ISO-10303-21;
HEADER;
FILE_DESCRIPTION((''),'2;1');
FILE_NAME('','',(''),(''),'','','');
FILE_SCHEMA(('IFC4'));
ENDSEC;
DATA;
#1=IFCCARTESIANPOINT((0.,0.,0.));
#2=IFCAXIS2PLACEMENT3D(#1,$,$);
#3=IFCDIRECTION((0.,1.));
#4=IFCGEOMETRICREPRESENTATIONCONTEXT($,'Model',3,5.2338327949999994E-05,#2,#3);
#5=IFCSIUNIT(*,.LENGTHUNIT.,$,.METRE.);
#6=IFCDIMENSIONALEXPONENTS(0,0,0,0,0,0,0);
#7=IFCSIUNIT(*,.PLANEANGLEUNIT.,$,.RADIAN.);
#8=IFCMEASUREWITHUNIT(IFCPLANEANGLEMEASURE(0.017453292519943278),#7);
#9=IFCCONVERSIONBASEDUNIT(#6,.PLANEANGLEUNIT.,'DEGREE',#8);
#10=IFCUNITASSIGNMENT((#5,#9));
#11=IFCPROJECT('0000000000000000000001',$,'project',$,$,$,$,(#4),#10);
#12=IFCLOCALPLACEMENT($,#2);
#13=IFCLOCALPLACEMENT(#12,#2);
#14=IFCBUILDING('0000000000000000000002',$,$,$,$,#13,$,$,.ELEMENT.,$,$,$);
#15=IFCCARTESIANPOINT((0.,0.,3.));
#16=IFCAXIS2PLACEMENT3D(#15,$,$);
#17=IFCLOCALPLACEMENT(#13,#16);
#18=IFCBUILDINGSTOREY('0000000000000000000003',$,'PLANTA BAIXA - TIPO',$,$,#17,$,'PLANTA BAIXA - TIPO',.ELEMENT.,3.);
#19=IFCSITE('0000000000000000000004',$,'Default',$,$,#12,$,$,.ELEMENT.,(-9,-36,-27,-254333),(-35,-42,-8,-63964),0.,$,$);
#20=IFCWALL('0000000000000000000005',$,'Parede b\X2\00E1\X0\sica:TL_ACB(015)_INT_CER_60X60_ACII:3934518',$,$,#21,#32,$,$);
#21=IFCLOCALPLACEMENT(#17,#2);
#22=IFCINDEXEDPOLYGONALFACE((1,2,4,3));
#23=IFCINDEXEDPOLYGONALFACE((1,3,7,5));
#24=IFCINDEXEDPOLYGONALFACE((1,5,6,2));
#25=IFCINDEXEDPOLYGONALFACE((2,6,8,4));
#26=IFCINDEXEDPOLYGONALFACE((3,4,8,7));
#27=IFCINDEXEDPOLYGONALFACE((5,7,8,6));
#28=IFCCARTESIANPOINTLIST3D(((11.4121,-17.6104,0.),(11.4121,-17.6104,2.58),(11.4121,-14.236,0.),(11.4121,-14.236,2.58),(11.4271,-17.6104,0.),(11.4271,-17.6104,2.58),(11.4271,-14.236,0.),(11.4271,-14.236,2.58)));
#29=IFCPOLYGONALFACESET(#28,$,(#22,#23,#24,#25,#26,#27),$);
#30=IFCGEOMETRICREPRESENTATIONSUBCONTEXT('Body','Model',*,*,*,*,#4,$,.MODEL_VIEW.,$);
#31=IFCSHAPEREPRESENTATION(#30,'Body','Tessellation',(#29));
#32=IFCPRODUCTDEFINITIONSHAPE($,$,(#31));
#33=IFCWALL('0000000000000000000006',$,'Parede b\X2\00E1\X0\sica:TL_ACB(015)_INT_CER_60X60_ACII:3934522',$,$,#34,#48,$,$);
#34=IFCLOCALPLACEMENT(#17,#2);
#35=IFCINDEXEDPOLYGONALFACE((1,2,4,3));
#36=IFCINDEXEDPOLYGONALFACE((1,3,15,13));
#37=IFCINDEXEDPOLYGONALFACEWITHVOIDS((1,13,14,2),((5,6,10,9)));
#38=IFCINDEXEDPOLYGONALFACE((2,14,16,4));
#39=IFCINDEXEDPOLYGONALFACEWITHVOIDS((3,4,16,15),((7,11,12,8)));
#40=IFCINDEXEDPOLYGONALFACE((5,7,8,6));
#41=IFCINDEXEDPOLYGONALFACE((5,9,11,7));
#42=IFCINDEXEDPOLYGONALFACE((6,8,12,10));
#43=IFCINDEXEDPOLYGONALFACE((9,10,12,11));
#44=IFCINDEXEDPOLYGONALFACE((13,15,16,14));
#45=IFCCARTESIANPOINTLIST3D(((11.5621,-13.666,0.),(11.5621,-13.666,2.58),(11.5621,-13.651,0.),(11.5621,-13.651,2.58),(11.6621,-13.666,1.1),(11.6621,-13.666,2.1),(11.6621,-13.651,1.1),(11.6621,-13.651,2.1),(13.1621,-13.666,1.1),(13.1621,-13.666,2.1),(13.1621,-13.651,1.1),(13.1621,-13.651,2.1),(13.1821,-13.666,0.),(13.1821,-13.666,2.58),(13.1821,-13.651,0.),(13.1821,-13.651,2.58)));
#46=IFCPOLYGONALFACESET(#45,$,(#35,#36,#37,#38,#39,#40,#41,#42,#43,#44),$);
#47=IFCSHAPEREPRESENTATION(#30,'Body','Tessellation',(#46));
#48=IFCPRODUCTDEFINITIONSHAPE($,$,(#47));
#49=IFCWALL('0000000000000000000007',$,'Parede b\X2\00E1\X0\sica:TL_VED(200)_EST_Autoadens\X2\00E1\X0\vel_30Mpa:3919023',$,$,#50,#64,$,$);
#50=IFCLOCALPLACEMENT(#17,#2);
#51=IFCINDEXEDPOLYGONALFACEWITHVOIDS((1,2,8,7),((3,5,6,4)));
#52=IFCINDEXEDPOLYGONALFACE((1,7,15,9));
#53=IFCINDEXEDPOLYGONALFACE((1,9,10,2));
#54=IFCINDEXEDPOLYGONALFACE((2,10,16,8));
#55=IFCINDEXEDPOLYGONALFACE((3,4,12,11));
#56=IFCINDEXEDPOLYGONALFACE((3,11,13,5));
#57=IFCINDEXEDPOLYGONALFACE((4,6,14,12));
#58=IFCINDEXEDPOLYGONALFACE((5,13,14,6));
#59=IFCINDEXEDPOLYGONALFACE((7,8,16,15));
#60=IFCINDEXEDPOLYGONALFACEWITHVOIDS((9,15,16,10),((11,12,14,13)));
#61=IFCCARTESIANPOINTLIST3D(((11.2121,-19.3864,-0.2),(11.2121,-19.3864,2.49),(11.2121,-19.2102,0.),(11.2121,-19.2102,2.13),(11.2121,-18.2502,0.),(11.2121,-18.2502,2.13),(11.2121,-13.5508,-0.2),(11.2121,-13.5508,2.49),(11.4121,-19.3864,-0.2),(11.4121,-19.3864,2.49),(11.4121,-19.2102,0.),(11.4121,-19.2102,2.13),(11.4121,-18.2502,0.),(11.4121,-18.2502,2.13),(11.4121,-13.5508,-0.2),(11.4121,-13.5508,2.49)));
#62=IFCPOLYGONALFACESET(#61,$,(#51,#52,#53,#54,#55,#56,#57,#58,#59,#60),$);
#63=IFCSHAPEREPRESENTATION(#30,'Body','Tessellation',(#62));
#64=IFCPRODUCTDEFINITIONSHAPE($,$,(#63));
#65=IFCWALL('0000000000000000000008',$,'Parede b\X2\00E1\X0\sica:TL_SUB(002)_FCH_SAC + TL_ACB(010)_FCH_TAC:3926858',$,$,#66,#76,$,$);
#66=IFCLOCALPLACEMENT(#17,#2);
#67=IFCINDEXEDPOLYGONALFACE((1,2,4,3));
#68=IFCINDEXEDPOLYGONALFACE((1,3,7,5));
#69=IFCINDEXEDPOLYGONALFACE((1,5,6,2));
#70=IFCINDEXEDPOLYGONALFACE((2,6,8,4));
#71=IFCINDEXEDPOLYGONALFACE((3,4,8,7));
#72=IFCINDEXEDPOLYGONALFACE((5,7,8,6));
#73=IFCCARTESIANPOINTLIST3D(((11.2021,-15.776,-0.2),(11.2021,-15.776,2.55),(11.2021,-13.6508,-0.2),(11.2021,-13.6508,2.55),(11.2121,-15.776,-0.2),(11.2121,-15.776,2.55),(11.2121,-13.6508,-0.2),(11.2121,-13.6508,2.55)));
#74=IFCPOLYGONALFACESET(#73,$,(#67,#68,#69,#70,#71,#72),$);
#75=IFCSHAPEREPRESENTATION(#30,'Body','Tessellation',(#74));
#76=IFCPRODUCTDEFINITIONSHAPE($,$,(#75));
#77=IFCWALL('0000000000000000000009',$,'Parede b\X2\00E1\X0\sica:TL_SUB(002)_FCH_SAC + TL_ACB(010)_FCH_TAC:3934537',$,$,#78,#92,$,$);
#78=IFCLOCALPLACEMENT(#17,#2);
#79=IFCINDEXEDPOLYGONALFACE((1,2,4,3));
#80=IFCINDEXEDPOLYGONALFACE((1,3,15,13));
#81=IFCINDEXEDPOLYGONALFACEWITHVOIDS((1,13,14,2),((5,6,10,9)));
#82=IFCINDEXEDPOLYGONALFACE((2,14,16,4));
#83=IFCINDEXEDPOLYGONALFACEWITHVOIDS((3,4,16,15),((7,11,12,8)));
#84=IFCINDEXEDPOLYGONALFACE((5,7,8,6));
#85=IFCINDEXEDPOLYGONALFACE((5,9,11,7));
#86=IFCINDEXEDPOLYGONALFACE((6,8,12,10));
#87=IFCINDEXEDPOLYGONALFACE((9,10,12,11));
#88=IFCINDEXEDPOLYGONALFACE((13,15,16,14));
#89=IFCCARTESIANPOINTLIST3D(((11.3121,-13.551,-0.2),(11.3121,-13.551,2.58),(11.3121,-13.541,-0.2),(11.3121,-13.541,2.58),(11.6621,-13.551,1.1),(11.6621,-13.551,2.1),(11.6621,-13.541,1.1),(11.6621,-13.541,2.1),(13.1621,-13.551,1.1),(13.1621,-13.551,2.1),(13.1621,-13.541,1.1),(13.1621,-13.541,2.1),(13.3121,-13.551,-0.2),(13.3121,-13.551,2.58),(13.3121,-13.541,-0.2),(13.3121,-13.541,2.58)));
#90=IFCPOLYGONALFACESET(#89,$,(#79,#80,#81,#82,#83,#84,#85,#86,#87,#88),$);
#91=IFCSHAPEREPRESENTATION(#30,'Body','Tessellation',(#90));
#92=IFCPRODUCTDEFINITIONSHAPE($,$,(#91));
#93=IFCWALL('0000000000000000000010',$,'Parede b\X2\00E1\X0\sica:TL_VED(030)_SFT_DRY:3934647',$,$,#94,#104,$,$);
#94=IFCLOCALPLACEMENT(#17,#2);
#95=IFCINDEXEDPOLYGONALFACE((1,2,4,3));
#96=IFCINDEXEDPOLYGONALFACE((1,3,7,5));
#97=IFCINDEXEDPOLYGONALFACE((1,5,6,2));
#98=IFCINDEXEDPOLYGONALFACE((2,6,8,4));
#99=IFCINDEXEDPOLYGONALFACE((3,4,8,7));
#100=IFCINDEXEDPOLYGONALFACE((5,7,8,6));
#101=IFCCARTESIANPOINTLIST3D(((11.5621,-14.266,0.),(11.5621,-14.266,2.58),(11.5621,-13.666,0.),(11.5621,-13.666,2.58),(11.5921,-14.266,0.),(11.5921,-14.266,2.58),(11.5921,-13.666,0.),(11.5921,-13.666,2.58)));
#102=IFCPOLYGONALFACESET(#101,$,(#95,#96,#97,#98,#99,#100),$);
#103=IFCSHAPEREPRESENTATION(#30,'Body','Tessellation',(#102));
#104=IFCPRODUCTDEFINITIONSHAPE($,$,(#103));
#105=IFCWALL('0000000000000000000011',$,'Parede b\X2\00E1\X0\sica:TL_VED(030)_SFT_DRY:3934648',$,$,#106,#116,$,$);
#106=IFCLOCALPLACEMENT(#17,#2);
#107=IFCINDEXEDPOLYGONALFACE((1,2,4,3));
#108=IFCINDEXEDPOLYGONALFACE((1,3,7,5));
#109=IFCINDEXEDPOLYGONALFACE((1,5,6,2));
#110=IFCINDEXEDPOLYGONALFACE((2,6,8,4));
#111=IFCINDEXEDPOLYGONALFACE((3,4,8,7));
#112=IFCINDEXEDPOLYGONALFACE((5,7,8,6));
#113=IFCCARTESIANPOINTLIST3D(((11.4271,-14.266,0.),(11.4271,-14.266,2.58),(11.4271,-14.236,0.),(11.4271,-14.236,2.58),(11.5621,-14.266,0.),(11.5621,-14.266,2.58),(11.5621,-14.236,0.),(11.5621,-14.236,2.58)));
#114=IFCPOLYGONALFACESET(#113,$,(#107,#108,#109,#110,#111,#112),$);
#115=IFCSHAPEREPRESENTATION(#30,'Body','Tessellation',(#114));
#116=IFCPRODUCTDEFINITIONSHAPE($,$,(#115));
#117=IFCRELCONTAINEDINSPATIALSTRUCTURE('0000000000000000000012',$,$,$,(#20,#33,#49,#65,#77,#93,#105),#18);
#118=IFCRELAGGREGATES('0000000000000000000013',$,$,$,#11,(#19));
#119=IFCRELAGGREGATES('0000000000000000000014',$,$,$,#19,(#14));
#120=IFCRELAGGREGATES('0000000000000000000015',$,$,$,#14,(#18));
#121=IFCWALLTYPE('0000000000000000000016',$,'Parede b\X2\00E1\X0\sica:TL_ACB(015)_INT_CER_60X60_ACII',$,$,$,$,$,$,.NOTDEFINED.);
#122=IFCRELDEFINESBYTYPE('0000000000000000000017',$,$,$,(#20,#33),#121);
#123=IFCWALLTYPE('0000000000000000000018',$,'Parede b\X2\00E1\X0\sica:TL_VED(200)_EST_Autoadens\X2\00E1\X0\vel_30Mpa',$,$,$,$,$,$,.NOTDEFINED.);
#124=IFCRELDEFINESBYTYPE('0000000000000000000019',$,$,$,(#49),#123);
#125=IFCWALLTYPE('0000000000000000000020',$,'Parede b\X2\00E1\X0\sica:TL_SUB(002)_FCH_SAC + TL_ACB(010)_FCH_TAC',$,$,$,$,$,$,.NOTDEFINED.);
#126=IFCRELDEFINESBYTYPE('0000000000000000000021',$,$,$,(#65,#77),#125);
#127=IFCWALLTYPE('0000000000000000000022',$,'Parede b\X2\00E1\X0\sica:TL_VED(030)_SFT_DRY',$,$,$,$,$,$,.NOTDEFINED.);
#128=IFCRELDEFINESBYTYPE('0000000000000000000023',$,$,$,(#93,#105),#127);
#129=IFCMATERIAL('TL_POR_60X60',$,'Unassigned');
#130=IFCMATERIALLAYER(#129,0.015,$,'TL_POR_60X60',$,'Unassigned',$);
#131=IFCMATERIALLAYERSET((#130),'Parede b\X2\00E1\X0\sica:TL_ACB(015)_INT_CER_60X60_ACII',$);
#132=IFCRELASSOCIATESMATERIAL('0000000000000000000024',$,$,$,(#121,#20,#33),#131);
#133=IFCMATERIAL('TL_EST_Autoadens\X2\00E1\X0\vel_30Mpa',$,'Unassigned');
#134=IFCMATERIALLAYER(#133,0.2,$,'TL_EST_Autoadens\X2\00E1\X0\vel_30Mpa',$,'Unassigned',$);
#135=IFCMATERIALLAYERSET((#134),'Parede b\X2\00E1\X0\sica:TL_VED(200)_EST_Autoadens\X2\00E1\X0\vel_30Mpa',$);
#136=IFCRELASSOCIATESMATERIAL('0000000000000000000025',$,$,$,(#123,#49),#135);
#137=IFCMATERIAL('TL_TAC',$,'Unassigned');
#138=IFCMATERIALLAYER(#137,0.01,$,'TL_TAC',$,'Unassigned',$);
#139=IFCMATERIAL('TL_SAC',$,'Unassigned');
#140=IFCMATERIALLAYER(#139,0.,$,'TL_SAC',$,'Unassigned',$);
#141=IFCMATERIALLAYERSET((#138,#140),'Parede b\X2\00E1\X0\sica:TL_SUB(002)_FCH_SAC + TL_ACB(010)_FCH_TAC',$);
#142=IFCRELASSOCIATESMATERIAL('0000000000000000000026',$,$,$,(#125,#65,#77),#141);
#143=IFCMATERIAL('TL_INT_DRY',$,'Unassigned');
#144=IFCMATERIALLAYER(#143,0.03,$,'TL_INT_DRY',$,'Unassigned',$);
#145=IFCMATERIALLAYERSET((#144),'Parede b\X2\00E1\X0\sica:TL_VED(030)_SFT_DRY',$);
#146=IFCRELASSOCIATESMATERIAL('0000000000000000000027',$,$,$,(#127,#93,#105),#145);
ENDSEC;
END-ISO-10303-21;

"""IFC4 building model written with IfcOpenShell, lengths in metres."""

from ifc_helpers import new_model, entity, si_unit, converted_unit, direction, frame, frame_2d, origin, place, context, subcontext, project, spatial, rectangle, extrude, material, layer, layer_set, layer_usage, type_object, element, save


model = new_model("IFC4")

# Units and contexts
model_context = context("Model", 3, precision=5.2338327949999994e-05, world=origin(), true_north=direction((0.0, 1.0)))
body_context = subcontext(model_context, "Body", "Model", "MODEL_VIEW")
ifc_project = project(units=[si_unit("LENGTHUNIT", "METRE"), converted_unit("PLANEANGLEUNIT", "DEGREE", entity("IfcPlaneAngleMeasure", 0.017453292519943278), si_unit("PLANEANGLEUNIT", "RADIAN"), dimensions=[0, 0, 0, 0, 0, 0, 0])], contexts=[model_context])

# Site, building, storey
site_placement = place(None, frame((0.0, 0.0, 0.0)))
site = spatial("IfcSite", under=ifc_project, at=site_placement, Name="Default", CompositionType="ELEMENT", RefLatitude=(-9, -36, -27, -254333), RefLongitude=(-35, -42, -8, -63964), RefElevation=0.0)
building_placement = place(site_placement, origin())
building = spatial("IfcBuilding", under=site, at=building_placement, CompositionType="ELEMENT")
storey_placement = place(building_placement, frame((0.0, 0.0, 3.0)))
storey = spatial("IfcBuildingStorey", under=building, at=storey_placement, Name="PLANTA BAIXA - TIPO", LongName="PLANTA BAIXA - TIPO", CompositionType="ELEMENT", Elevation=3.0)

# Shared definitions
ifc_material_1 = material(Name="TL_POR_60X60", Category="Unassigned")

# Shared definitions
ifc_material_2 = material(Name="TL_EST_Autoadensável_30Mpa", Category="Unassigned")
ifc_material_3 = material(Name="TL_SAC", Category="Unassigned")

# Wall
ifc_layer_1 = layer(ifc_material_1, 0.015, Name="TL_POR_60X60", Category="Unassigned")
ifc_layer_set_1 = layer_set([ifc_layer_1], Name="Parede básica:TL_ACB(015)_INT_CER_60X60_ACII")
ifc_layer_usage_1 = layer_usage(ifc_layer_set_1, "AXIS2", "POSITIVE", -0.0075)
wall_type_1 = type_object("IfcWallType", Name="Parede básica:TL_ACB(015)_INT_CER_60X60_ACII", PredefinedType="NOTDEFINED", material=ifc_layer_set_1)
wall_1_placement = place(storey_placement, frame((11.4196, -17.6104, 0.0), z_axis=(0.0, 0.0, 1.0), x_axis=(0.0, 1.0, 0.0)))
element("IfcWall", 1, at=wall_1_placement, inside=storey, type_object=wall_type_1, material=ifc_layer_usage_1, Name="Parede básica:TL_ACB(015)_INT_CER_60X60_ACII:3934518", context=body_context, shape_type="SweptSolid", body=[
    extrude(rectangle(XDim=3.3744, YDim=0.015, at=frame_2d((1.6872, 0.0), x_axis=(-1.0, 0.0))), origin(), (0.0, 0.0, 1.0), 2.58),
])

# Walls, openings
ifc_layer_usage_2 = layer_usage(ifc_layer_set_1, "AXIS2", "POSITIVE", -0.0075)
wall_2_placement = place(storey_placement, frame((11.5621, -13.6585, 0.0)))
wall_2 = element("IfcWall", 2, at=wall_2_placement, inside=storey, type_object=wall_type_1, material=ifc_layer_usage_2, Name="Parede básica:TL_ACB(015)_INT_CER_60X60_ACII:3934522", context=body_context, shape_type="SweptSolid", body=[
    extrude(rectangle(XDim=1.62, YDim=0.015, at=frame_2d((0.81, 0.0), x_axis=(-1.0, 0.0))), origin(), (0.0, 0.0, 1.0), 2.58),
])
opening_1_placement = place(wall_2_placement, frame((-11.5621, 13.6585, 1.1)))
element("IfcOpeningElement", 3, at=opening_1_placement, cuts=wall_2, PredefinedType="OPENING", context=body_context, shape_type="SweptSolid", body=[
    extrude(rectangle(XDim=1.0, YDim=1.5, at=frame_2d((0.0, 0.0), x_axis=(0.0, 1.0))), frame((12.4121, -15.175, 0.5), z_axis=(0.0, 1.0, 0.0), x_axis=(1.0, 0.0, 0.0)), (0.0, 0.0, 1.0), 3.048),
])
ifc_layer_2 = layer(ifc_material_2, 0.2, Name="TL_EST_Autoadensável_30Mpa", Category="Unassigned")
ifc_layer_set_2 = layer_set([ifc_layer_2], Name="Parede básica:TL_VED(200)_EST_Autoadensável_30Mpa")
ifc_layer_usage_3 = layer_usage(ifc_layer_set_2, "AXIS2", "POSITIVE", -0.1)
wall_type_2 = type_object("IfcWallType", Name="Parede básica:TL_VED(200)_EST_Autoadensável_30Mpa", PredefinedType="NOTDEFINED", material=ifc_layer_set_2)
wall_3_placement = place(storey_placement, frame((11.3121, -13.5508, -0.2), z_axis=(0.0, 0.0, 1.0), x_axis=(0.0, -1.0, 0.0)))
wall_3 = element("IfcWall", 4, at=wall_3_placement, inside=storey, type_object=wall_type_2, material=ifc_layer_usage_3, Name="Parede básica:TL_VED(200)_EST_Autoadensável_30Mpa:3919023", context=body_context, shape_type="SweptSolid", body=[
    extrude(rectangle(XDim=5.8355, YDim=0.2, at=frame_2d((2.9178, 0.0), x_axis=(-1.0, 0.0))), origin(), (0.0, 0.0, 1.0), 2.69),
])
opening_2_placement = place(wall_3_placement, frame((4.6993, -0.1, 0.2)))
element("IfcOpeningElement", 5, at=opening_2_placement, cuts=wall_3, PredefinedType="OPENING", context=body_context, shape_type="SweptSolid", body=[
    extrude(rectangle(XDim=2.13, YDim=0.96, at=frame_2d((1.065, 0.48), x_axis=(1.0, 0.0))), frame((0.0, 0.0, 0.0), z_axis=(0.0, 1.0, 0.0), x_axis=(0.0, 0.0, 1.0)), (0.0, 0.0, 1.0), 0.2),
])

# Wall
ifc_material_4 = material(Name="TL_TAC", Category="Unassigned")
ifc_layer_3 = layer(ifc_material_4, 0.01, Name="TL_TAC", Category="Unassigned")
ifc_layer_4 = layer(ifc_material_3, 0.0, Name="TL_SAC", Category="Unassigned")
ifc_layer_set_3 = layer_set([ifc_layer_3, ifc_layer_4], Name="Parede básica:TL_SUB(002)_FCH_SAC + TL_ACB(010)_FCH_TAC")
ifc_layer_usage_4 = layer_usage(ifc_layer_set_3, "AXIS2", "NEGATIVE", 0.005)
wall_type_3 = type_object("IfcWallType", Name="Parede básica:TL_SUB(002)_FCH_SAC + TL_ACB(010)_FCH_TAC", PredefinedType="NOTDEFINED", material=ifc_layer_set_3)
wall_4_placement = place(storey_placement, frame((11.2071, -13.6508, -0.2), z_axis=(0.0, 0.0, 1.0), x_axis=(0.0, -1.0, 0.0)))
element("IfcWall", 6, at=wall_4_placement, inside=storey, type_object=wall_type_3, material=ifc_layer_usage_4, Name="Parede básica:TL_SUB(002)_FCH_SAC + TL_ACB(010)_FCH_TAC:3926858", context=body_context, shape_type="SweptSolid", body=[
    extrude(rectangle(XDim=2.1251, YDim=0.01, at=frame_2d((1.0626, 0.0), x_axis=(-1.0, 0.0))), origin(), (0.0, 0.0, 1.0), 2.75),
])

# Wall, opening
ifc_layer_usage_5 = layer_usage(ifc_layer_set_3, "AXIS2", "POSITIVE", -0.005)
wall_5_placement = place(storey_placement, frame((11.3121, -13.546, -0.2)))
wall_5 = element("IfcWall", 7, at=wall_5_placement, inside=storey, type_object=wall_type_3, material=ifc_layer_usage_5, Name="Parede básica:TL_SUB(002)_FCH_SAC + TL_ACB(010)_FCH_TAC:3934537", context=body_context, shape_type="SweptSolid", body=[
    extrude(rectangle(XDim=2.0, YDim=0.01, at=frame_2d((1.0, 0.0), x_axis=(-1.0, 0.0))), origin(), (0.0, 0.0, 1.0), 2.78),
])
opening_3_placement = place(wall_5_placement, frame((-11.3121, 13.546, 1.3)))
element("IfcOpeningElement", 8, at=opening_3_placement, cuts=wall_5, PredefinedType="OPENING", context=body_context, shape_type="SweptSolid", body=[
    extrude(rectangle(XDim=1.0, YDim=1.5, at=frame_2d((0.0, 0.0), x_axis=(0.0, 1.0))), frame((12.4121, -15.175, 0.5), z_axis=(0.0, 1.0, 0.0), x_axis=(1.0, 0.0, 0.0)), (0.0, 0.0, 1.0), 3.048),
])

# Walls
ifc_material_5 = material(Name="TL_INT_DRY", Category="Unassigned")
ifc_layer_5 = layer(ifc_material_5, 0.03, Name="TL_INT_DRY", Category="Unassigned")
ifc_layer_set_4 = layer_set([ifc_layer_5], Name="Parede básica:TL_VED(030)_SFT_DRY")
ifc_layer_usage_6 = layer_usage(ifc_layer_set_4, "AXIS2", "NEGATIVE", 0.015)
wall_type_4 = type_object("IfcWallType", Name="Parede básica:TL_VED(030)_SFT_DRY", PredefinedType="NOTDEFINED", material=ifc_layer_set_4)
wall_6_placement = place(storey_placement, frame((11.5771, -13.666, 0.0), z_axis=(0.0, 0.0, 1.0), x_axis=(0.0, -1.0, 0.0)))
element("IfcWall", 9, at=wall_6_placement, inside=storey, type_object=wall_type_4, material=ifc_layer_usage_6, Name="Parede básica:TL_VED(030)_SFT_DRY:3934647", context=body_context, shape_type="SweptSolid", body=[
    extrude(rectangle(XDim=0.6, YDim=0.03, at=frame_2d((0.3, 0.0), x_axis=(-1.0, 0.0))), origin(), (0.0, 0.0, 1.0), 2.58),
])
ifc_layer_usage_7 = layer_usage(ifc_layer_set_4, "AXIS2", "NEGATIVE", 0.015)
wall_7_placement = place(storey_placement, frame((11.5621, -14.251, 0.0), z_axis=(0.0, 0.0, 1.0), x_axis=(-1.0, 0.0, 0.0)))
element("IfcWall", 10, at=wall_7_placement, inside=storey, type_object=wall_type_4, material=ifc_layer_usage_7, Name="Parede básica:TL_VED(030)_SFT_DRY:3934648", context=body_context, shape_type="SweptSolid", body=[
    extrude(rectangle(XDim=0.135, YDim=0.03, at=frame_2d((0.0675, 0.0), x_axis=(-1.0, 0.0))), origin(), (0.0, 0.0, 1.0), 2.58),
])

save(model, "model.ifc")
